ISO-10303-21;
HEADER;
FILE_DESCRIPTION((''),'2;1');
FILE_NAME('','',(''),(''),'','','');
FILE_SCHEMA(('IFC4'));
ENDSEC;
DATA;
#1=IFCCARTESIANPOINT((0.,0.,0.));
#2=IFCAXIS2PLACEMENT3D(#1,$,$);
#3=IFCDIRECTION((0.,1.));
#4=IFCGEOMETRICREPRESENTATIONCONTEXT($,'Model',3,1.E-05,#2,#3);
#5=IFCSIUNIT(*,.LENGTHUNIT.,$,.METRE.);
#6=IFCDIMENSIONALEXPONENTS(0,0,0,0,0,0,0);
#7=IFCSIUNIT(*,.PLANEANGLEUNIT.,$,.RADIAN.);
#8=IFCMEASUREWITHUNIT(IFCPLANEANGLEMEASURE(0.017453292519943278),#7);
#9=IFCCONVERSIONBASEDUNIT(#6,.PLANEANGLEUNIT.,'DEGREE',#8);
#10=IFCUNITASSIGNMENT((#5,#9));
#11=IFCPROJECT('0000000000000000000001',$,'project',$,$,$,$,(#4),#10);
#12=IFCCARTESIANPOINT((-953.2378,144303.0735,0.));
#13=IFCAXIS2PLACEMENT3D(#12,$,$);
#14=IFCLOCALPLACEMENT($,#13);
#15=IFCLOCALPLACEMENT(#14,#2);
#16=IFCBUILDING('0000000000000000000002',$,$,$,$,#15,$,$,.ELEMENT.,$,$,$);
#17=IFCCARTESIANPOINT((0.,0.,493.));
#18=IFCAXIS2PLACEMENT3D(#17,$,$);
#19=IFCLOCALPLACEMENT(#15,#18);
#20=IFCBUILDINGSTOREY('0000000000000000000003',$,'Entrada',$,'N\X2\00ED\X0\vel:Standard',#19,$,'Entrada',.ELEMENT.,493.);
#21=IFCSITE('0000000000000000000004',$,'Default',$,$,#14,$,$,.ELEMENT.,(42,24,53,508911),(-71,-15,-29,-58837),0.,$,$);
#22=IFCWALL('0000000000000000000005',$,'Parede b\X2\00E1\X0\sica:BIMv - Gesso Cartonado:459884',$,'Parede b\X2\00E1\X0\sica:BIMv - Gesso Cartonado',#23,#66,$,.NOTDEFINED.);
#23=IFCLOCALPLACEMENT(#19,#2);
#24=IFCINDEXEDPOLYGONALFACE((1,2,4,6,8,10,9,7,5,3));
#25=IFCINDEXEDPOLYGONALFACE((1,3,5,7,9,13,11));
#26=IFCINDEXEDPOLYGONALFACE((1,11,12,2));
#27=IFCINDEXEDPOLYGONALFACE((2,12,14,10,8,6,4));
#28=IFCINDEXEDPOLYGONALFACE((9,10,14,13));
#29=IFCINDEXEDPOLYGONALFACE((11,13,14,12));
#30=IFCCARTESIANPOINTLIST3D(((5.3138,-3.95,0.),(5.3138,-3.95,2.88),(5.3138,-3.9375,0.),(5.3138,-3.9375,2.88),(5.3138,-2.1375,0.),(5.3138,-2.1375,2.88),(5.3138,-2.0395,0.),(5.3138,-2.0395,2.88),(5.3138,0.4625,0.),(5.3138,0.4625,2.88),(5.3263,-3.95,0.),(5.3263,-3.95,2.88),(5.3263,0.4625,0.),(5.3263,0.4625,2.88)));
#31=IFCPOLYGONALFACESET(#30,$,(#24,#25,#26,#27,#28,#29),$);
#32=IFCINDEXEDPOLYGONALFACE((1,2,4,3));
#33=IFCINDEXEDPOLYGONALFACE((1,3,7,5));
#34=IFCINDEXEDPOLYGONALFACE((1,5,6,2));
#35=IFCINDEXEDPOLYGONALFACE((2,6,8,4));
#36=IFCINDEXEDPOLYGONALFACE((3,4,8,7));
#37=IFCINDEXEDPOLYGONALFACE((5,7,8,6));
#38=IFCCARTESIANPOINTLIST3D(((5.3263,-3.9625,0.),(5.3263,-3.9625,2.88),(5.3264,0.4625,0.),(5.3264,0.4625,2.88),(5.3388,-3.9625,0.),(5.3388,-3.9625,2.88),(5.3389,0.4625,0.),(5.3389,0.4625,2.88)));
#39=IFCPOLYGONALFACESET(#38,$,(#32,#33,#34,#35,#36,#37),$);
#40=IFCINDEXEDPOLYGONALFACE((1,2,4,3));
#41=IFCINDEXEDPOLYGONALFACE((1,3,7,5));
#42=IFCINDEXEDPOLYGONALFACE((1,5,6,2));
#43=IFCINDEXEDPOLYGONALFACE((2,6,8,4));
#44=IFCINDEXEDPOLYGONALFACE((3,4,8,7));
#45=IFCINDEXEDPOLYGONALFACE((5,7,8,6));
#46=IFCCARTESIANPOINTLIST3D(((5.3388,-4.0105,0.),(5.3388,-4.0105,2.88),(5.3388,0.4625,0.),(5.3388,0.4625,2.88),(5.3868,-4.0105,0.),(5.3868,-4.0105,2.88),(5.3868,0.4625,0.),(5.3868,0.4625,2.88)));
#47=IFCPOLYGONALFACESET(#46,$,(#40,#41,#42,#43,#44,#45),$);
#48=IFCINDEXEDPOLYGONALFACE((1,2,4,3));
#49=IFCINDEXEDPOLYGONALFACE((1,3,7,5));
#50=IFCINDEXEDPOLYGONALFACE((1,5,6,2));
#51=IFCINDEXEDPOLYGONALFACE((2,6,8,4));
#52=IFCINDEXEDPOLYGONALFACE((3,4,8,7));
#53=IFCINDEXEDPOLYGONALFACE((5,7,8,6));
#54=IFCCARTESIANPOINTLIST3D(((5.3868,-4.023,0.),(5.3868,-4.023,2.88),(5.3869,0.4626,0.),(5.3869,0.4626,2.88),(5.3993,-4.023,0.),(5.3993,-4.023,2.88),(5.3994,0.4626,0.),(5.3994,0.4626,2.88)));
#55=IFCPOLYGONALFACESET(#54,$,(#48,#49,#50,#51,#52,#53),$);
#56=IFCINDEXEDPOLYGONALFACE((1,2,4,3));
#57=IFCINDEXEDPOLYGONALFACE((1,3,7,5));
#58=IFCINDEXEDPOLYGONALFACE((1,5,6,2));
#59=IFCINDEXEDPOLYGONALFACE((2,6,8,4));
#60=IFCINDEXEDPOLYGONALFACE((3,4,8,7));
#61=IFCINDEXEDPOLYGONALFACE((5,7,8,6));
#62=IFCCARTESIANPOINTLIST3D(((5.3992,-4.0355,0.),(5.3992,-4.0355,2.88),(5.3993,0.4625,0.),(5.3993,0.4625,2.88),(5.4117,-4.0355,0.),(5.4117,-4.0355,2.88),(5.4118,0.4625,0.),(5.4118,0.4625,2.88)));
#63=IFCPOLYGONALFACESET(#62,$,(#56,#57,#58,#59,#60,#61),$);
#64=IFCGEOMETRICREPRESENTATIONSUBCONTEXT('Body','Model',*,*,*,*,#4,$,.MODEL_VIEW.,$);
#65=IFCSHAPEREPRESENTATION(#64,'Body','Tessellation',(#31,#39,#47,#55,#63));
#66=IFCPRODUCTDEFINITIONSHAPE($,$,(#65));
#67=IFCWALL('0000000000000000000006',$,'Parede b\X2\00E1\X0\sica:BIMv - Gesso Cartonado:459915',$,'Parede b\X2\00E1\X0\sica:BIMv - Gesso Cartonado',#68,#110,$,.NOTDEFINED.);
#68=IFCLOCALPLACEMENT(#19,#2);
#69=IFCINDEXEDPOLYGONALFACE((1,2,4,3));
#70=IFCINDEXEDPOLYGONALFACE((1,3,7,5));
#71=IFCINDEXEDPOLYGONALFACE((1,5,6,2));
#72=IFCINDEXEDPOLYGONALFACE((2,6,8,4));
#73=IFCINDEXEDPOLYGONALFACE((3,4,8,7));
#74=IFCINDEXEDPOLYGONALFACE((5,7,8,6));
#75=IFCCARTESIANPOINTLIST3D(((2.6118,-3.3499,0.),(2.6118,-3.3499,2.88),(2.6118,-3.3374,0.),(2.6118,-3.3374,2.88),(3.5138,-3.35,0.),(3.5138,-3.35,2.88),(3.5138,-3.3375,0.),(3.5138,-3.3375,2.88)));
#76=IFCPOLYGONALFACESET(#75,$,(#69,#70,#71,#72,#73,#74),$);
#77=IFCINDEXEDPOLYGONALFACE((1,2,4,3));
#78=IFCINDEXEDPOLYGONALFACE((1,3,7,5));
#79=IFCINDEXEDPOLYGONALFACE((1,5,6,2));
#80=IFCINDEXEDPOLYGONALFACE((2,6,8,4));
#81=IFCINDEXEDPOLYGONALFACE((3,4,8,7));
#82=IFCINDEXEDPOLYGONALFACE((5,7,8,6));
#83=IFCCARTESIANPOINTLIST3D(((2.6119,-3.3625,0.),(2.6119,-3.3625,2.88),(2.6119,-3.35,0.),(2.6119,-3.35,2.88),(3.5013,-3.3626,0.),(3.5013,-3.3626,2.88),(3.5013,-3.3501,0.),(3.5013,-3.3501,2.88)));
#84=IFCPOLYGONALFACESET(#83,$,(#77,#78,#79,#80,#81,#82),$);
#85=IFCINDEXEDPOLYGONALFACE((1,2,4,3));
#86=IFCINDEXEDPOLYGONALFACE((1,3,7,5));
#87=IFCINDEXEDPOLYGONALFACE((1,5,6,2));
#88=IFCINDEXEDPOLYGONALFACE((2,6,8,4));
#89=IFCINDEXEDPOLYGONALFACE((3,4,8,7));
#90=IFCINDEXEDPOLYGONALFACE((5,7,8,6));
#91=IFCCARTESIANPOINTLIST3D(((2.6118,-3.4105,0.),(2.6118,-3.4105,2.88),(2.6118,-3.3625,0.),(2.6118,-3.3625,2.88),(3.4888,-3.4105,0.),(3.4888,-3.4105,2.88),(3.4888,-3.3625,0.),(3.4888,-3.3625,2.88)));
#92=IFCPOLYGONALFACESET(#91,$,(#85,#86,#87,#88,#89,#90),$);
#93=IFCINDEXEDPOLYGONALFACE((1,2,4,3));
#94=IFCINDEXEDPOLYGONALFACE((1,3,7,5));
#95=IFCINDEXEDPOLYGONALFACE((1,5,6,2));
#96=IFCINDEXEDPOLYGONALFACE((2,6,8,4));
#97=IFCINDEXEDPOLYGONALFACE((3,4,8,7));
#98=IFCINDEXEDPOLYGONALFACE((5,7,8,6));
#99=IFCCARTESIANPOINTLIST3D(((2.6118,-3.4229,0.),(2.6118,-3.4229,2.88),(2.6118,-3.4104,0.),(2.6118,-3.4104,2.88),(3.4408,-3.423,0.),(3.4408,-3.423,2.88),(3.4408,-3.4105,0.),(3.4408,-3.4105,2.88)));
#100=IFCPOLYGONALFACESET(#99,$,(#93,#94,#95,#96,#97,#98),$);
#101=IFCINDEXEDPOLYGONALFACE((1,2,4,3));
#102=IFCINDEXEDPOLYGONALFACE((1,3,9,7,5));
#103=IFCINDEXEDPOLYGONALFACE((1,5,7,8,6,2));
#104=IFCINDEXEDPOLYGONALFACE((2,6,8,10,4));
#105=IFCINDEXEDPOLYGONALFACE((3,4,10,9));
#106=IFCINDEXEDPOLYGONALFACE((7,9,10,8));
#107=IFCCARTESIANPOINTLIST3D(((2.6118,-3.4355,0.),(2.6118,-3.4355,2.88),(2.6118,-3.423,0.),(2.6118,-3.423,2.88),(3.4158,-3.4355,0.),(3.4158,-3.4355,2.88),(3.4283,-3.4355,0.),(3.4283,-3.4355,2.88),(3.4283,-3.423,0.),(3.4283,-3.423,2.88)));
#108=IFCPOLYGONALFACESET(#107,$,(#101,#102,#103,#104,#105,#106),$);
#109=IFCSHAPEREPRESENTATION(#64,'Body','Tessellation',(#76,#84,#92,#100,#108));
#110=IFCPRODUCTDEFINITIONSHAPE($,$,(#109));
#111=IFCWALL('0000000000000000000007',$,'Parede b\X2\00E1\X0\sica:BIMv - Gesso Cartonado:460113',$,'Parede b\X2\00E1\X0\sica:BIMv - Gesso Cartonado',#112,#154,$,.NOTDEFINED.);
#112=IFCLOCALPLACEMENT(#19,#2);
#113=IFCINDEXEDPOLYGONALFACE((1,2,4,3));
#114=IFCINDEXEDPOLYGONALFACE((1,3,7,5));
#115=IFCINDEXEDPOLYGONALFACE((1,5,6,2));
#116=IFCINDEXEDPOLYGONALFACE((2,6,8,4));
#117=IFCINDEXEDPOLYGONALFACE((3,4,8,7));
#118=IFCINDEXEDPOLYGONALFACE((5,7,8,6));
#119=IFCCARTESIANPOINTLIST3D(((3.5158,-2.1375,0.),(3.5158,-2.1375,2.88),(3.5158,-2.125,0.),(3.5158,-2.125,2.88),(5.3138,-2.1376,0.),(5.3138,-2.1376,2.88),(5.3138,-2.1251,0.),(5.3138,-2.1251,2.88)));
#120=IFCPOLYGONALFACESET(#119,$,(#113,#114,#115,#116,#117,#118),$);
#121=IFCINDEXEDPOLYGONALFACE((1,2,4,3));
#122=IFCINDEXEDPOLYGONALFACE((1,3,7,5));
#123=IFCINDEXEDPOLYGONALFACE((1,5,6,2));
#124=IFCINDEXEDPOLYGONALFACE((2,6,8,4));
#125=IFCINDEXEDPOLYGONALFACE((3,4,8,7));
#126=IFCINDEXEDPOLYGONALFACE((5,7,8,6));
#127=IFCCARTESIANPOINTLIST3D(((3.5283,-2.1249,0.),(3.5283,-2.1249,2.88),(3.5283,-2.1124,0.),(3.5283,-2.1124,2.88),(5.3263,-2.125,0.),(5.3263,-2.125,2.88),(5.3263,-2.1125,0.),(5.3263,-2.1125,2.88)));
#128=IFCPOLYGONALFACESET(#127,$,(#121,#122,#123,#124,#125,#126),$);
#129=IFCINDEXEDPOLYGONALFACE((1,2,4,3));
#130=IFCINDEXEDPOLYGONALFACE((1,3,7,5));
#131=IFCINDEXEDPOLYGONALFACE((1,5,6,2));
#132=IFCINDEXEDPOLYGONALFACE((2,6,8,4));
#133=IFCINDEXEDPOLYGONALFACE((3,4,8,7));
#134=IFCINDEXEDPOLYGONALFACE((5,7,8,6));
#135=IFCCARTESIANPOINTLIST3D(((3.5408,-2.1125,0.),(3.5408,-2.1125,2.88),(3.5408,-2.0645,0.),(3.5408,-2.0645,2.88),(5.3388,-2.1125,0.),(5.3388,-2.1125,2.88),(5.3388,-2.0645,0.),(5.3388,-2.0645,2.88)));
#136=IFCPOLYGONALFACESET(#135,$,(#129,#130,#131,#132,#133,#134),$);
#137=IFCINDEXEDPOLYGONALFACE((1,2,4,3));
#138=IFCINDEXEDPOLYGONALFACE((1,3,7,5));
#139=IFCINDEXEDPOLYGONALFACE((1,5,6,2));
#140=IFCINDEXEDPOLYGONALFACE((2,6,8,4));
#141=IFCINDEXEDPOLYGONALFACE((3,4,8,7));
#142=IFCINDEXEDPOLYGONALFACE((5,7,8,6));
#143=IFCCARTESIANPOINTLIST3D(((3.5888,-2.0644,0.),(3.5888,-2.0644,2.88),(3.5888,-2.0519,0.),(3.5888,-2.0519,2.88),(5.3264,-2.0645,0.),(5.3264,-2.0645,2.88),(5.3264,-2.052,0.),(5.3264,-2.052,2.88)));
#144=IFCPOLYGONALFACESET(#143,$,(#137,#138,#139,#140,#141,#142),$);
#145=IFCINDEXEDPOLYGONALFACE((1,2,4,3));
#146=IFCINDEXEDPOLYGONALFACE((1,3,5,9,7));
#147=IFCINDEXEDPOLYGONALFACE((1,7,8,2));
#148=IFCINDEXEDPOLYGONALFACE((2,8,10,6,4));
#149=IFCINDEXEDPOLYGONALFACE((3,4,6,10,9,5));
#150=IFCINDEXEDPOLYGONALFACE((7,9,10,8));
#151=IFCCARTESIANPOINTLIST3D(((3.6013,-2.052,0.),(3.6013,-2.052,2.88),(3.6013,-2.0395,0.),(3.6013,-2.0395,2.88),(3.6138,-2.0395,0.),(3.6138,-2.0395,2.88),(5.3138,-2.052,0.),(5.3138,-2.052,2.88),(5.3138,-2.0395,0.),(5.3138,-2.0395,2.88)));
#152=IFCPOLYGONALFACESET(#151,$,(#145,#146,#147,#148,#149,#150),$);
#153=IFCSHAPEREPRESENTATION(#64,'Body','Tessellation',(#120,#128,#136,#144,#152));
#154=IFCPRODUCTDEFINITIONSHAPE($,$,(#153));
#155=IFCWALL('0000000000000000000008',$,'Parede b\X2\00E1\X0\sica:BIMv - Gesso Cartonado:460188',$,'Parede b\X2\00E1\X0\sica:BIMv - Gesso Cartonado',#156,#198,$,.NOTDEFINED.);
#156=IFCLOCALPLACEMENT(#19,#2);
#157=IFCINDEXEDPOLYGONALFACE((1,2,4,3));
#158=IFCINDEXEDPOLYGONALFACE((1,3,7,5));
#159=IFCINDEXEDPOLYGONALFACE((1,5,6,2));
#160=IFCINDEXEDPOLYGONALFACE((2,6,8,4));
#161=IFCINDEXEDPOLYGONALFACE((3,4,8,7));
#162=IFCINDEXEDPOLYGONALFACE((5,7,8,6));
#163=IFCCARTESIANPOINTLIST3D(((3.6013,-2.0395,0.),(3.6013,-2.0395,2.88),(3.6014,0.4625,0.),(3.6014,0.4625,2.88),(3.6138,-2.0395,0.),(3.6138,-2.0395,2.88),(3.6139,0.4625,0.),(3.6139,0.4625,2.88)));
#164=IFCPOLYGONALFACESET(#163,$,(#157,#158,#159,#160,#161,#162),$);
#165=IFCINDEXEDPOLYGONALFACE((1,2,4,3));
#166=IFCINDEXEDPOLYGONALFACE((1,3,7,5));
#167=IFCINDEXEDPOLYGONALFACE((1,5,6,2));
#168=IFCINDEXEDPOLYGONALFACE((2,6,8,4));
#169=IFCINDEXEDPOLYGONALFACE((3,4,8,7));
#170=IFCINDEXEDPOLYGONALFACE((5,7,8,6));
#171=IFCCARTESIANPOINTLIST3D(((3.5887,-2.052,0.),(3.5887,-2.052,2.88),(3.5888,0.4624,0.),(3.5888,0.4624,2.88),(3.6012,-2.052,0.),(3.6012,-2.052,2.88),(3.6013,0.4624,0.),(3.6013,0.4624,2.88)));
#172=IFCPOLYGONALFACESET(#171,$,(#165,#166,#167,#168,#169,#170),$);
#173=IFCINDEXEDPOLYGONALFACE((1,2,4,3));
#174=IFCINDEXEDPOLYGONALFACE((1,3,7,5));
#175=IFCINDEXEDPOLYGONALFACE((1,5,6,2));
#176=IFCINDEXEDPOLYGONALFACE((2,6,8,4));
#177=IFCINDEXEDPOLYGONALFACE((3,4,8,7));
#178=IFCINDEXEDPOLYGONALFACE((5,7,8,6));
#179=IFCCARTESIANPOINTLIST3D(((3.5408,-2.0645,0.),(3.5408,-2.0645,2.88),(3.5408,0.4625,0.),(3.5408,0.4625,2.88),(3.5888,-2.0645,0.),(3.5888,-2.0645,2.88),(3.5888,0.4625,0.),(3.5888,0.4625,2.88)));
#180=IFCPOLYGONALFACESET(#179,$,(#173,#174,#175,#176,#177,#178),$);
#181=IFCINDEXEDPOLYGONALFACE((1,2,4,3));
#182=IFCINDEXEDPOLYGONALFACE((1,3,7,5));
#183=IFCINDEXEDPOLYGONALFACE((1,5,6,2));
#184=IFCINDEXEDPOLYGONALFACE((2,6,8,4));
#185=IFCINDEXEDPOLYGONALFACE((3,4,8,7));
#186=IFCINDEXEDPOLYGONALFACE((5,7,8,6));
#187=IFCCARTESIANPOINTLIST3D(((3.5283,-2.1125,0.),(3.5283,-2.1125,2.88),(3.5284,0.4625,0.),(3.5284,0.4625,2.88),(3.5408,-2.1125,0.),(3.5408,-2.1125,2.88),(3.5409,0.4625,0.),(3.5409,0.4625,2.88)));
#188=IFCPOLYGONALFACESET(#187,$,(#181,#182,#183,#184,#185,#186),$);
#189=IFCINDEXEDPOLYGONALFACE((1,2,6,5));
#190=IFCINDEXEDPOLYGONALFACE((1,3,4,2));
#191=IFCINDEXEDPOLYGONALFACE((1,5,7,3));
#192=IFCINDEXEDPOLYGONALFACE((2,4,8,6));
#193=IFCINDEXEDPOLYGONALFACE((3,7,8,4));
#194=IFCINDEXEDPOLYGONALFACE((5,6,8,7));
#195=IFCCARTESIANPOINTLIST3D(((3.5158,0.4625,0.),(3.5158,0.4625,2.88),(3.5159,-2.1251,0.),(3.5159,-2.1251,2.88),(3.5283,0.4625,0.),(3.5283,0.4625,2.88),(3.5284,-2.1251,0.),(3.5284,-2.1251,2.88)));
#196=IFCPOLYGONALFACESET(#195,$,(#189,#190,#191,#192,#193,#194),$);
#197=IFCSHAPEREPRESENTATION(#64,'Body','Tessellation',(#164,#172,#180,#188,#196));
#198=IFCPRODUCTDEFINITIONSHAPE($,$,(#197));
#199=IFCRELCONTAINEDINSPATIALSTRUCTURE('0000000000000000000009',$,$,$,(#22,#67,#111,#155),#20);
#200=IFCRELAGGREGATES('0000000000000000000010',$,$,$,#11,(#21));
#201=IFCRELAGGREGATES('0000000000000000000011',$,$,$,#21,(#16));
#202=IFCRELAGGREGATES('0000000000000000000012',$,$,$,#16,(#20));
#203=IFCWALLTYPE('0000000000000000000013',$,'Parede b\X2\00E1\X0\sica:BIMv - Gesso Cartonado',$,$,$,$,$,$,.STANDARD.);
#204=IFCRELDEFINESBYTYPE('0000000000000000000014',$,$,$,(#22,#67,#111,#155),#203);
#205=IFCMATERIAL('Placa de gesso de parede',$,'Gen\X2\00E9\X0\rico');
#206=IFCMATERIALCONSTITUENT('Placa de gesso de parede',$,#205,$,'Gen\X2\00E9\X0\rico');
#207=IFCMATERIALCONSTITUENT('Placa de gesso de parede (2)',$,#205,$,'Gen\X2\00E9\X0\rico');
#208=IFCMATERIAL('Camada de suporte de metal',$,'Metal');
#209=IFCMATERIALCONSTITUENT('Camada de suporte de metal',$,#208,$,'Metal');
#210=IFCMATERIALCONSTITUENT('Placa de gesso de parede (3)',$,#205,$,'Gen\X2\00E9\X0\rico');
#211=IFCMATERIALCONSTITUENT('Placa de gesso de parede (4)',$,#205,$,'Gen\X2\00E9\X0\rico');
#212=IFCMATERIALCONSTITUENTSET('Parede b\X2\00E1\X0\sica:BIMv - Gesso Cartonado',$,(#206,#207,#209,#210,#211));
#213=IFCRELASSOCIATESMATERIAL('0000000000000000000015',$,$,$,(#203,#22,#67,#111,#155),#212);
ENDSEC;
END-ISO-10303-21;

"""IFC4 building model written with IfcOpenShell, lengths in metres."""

from ifc_helpers import new_model, entity, si_unit, converted_unit, direction, frame, origin, place, context, subcontext, project, spatial, indexed_curve, outline, extrude, material, constituent, constituent_set, type_object, element, save


model = new_model("IFC4")

# Units and contexts
model_context = context("Model", 3, precision=1e-05, world=origin(), true_north=direction((0.0, 1.0)))
body_context = subcontext(model_context, "Body", "Model", "MODEL_VIEW")
ifc_project = project(units=[si_unit("LENGTHUNIT", "METRE"), converted_unit("PLANEANGLEUNIT", "DEGREE", entity("IfcPlaneAngleMeasure", 0.017453292519943278), si_unit("PLANEANGLEUNIT", "RADIAN"), dimensions=[0, 0, 0, 0, 0, 0, 0])], contexts=[model_context])

# Site, building, storey
site_placement = place(None, frame((-953.2378, 144303.0735, 0.0)))
site = spatial("IfcSite", under=ifc_project, at=site_placement, Name="Default", CompositionType="ELEMENT", RefLatitude=(42, 24, 53, 508911), RefLongitude=(-71, -15, -29, -58837), RefElevation=0.0)
building_placement = place(site_placement, origin())
building = spatial("IfcBuilding", under=site, at=building_placement, CompositionType="ELEMENT")
storey_placement = place(building_placement, frame((0.0, 0.0, 493.0)))
storey = spatial("IfcBuildingStorey", under=building, at=storey_placement, Name="Entrada", ObjectType="Nível:Standard", LongName="Entrada", CompositionType="ELEMENT", Elevation=493.0)

# Walls
ifc_material_1 = material(Name="Placa de gesso de parede", Category="Genérico")
ifc_constituent_1 = constituent(ifc_material_1, Name="Placa de gesso de parede", Category="Genérico")
ifc_constituent_2 = constituent(ifc_material_1, Name="Placa de gesso de parede (2)", Category="Genérico")
ifc_material_2 = material(Name="Camada de suporte de metal", Category="Metal")
ifc_constituent_3 = constituent(ifc_material_2, Name="Camada de suporte de metal", Category="Metal")
ifc_constituent_4 = constituent(ifc_material_1, Name="Placa de gesso de parede (3)", Category="Genérico")
ifc_constituent_5 = constituent(ifc_material_1, Name="Placa de gesso de parede (4)", Category="Genérico")
ifc_constituent_set_1 = constituent_set(constituents=[ifc_constituent_1, ifc_constituent_2, ifc_constituent_3, ifc_constituent_4, ifc_constituent_5], Name="Parede básica:BIMv - Gesso Cartonado")
wall_type = type_object("IfcWallType", Name="Parede básica:BIMv - Gesso Cartonado", PredefinedType="STANDARD", material=ifc_constituent_set_1)
wall_1_placement = place(storey_placement, frame((5.3628, 0.4625, 0.0), z_axis=(0.0, 0.0, 1.0), x_axis=(0.0, -1.0, 0.0)))
element("IfcWall", 1, at=wall_1_placement, inside=storey, type_object=wall_type, material=ifc_constituent_set_1, Name="Parede básica:BIMv - Gesso Cartonado:459884", ObjectType="Parede básica:BIMv - Gesso Cartonado", PredefinedType="NOTDEFINED", context=body_context, shape_type="SweptSolid", body=[
    extrude(outline(indexed_curve([(-0.1161, -0.0036), (-0.0181, -0.0036), (1.7819, -0.0036), (1.7944, -0.0036), (1.7944, 0.0089), (-2.6181, 0.0089), (-2.6181, -0.0036), (-0.1161, -0.0036)], self_intersect=False)), frame((2.6181, -0.0454, 0.0)), (0.0, 0.0, 1.0), 2.88),
    extrude(outline(indexed_curve([(-0.0063, -2.2125), (0.0062, -2.2125), (0.0063, 2.2125), (-0.0062, 2.2125), (-0.0063, -2.2125)], self_intersect=False)), frame((2.2125, -0.0302, 0.0), z_axis=(0.0, 0.0, 1.0), x_axis=(0.0, 1.0, 0.0)), (0.0, 0.0, 1.0), 2.88),
    extrude(outline(indexed_curve([(-0.024, -2.2365), (0.024, -2.2365), (0.024, 2.2365), (-0.024, 2.2365), (-0.024, -2.2365)], self_intersect=False)), frame((2.2365, 0.0, 0.0), z_axis=(0.0, 0.0, 1.0), x_axis=(0.0, 1.0, 0.0)), (0.0, 0.0, 1.0), 2.88),
    extrude(outline(indexed_curve([(-0.0063, -2.2428), (0.0062, -2.2428), (0.0063, 2.2428), (-0.0062, 2.2428), (-0.0063, -2.2428)], self_intersect=False)), frame((2.2427, 0.0303, 0.0), z_axis=(0.0, 0.0, 1.0), x_axis=(0.0, 1.0, 0.0)), (0.0, 0.0, 1.0), 2.88),
    extrude(outline(indexed_curve([(-0.0063, -2.249), (0.0062, -2.249), (0.0063, 2.249), (-0.0062, 2.249), (-0.0063, -2.249)], self_intersect=False)), frame((2.249, 0.0427, 0.0), z_axis=(0.0, 0.0, 1.0), x_axis=(0.0, 1.0, 0.0)), (0.0, 0.0, 1.0), 2.88),
])
wall_2_placement = place(storey_placement, frame((3.5138, -3.3865, 0.0), z_axis=(0.0, 0.0, 1.0), x_axis=(-1.0, 0.0, 0.0)))
element("IfcWall", 2, at=wall_2_placement, inside=storey, type_object=wall_type, material=ifc_constituent_set_1, Name="Parede básica:BIMv - Gesso Cartonado:459915", ObjectType="Parede básica:BIMv - Gesso Cartonado", PredefinedType="NOTDEFINED", context=body_context, shape_type="SweptSolid", body=[
    extrude(outline(indexed_curve([(-0.0063, -0.451), (0.0062, -0.451), (0.0063, 0.451), (-0.0062, 0.451), (-0.0063, -0.451)], self_intersect=False)), frame((0.451, -0.0428, 0.0), z_axis=(0.0, 0.0, 1.0), x_axis=(0.0, 1.0, 0.0)), (0.0, 0.0, 1.0), 2.88),
    extrude(outline(indexed_curve([(-0.4447, -0.0062), (0.4447, -0.0063), (0.4447, 0.0062), (-0.4447, 0.0063), (-0.4447, -0.0062)], self_intersect=False)), frame((0.4572, -0.0302, 0.0)), (0.0, 0.0, 1.0), 2.88),
    extrude(outline(indexed_curve([(-0.4385, -0.024), (0.4385, -0.024), (0.4385, 0.024), (-0.4385, 0.024), (-0.4385, -0.024)], self_intersect=False)), frame((0.4635, 0.0, 0.0)), (0.0, 0.0, 1.0), 2.88),
    extrude(outline(indexed_curve([(-0.4145, -0.0062), (0.4145, -0.0063), (0.4145, 0.0062), (-0.4145, 0.0063), (-0.4145, -0.0062)], self_intersect=False)), frame((0.4875, 0.0302, 0.0)), (0.0, 0.0, 1.0), 2.88),
    extrude(outline(indexed_curve([(0.3166, -0.005), (0.3291, -0.005), (0.3291, 0.0075), (-0.4874, 0.0075), (-0.4874, -0.005), (0.3166, -0.005)], self_intersect=False)), frame((0.4146, 0.044, 0.0), z_axis=(0.0, 0.0, 1.0), x_axis=(-1.0, 0.0, 0.0)), (0.0, 0.0, 1.0), 2.88),
])
wall_3_placement = place(storey_placement, frame((3.5158, -2.0885, 0.0)))
element("IfcWall", 3, at=wall_3_placement, inside=storey, type_object=wall_type, material=ifc_constituent_set_1, Name="Parede básica:BIMv - Gesso Cartonado:460113", ObjectType="Parede básica:BIMv - Gesso Cartonado", PredefinedType="NOTDEFINED", context=body_context, shape_type="SweptSolid", body=[
    extrude(outline(indexed_curve([(-0.0063, -0.899), (0.0062, -0.899), (0.0063, 0.899), (-0.0062, 0.899), (-0.0063, -0.899)], self_intersect=False)), frame((0.899, -0.0428, 0.0), z_axis=(0.0, 0.0, 1.0), x_axis=(0.0, 1.0, 0.0)), (0.0, 0.0, 1.0), 2.88),
    extrude(outline(indexed_curve([(-0.899, -0.0062), (0.899, -0.0063), (0.899, 0.0062), (-0.899, 0.0063), (-0.899, -0.0062)], self_intersect=False)), frame((0.9115, -0.0302, 0.0)), (0.0, 0.0, 1.0), 2.88),
    extrude(outline(indexed_curve([(-0.899, -0.024), (0.899, -0.024), (0.899, 0.024), (-0.899, 0.024), (-0.899, -0.024)], self_intersect=False)), frame((0.924, 0.0, 0.0)), (0.0, 0.0, 1.0), 2.88),
    extrude(outline(indexed_curve([(-0.8688, -0.0062), (0.8688, -0.0063), (0.8688, 0.0062), (-0.8688, 0.0063), (-0.8688, -0.0062)], self_intersect=False)), frame((0.9418, 0.0303, 0.0)), (0.0, 0.0, 1.0), 2.88),
    extrude(outline(indexed_curve([(0.675, -0.005), (0.6875, -0.005), (0.6875, 0.0075), (-1.025, 0.0075), (-1.025, -0.005), (0.675, -0.005)], self_intersect=False)), frame((0.773, 0.044, 0.0), z_axis=(0.0, 0.0, 1.0), x_axis=(-1.0, 0.0, 0.0)), (0.0, 0.0, 1.0), 2.88),
])
wall_4_placement = place(storey_placement, frame((3.5648, -2.0395, 0.0), z_axis=(0.0, 0.0, 1.0), x_axis=(0.0, 1.0, 0.0)))
element("IfcWall", 4, at=wall_4_placement, inside=storey, type_object=wall_type, material=ifc_constituent_set_1, Name="Parede básica:BIMv - Gesso Cartonado:460188", ObjectType="Parede básica:BIMv - Gesso Cartonado", PredefinedType="NOTDEFINED", context=body_context, shape_type="SweptSolid", body=[
    extrude(outline(indexed_curve([(-0.0063, -1.251), (0.0062, -1.251), (0.0063, 1.251), (-0.0062, 1.251), (-0.0063, -1.251)], self_intersect=False)), frame((1.251, -0.0428, 0.0), z_axis=(0.0, 0.0, 1.0), x_axis=(0.0, 1.0, 0.0)), (0.0, 0.0, 1.0), 2.88),
    extrude(outline(indexed_curve([(-0.0063, -1.2572), (0.0062, -1.2572), (0.0063, 1.2572), (-0.0062, 1.2572), (-0.0063, -1.2572)], self_intersect=False)), frame((1.2447, -0.0302, 0.0), z_axis=(0.0, 0.0, 1.0), x_axis=(0.0, 1.0, 0.0)), (0.0, 0.0, 1.0), 2.88),
    extrude(outline(indexed_curve([(-0.024, -1.2635), (0.024, -1.2635), (0.024, 1.2635), (-0.024, 1.2635), (-0.024, -1.2635)], self_intersect=False)), frame((1.2385, 0.0, 0.0), z_axis=(0.0, 0.0, 1.0), x_axis=(0.0, 1.0, 0.0)), (0.0, 0.0, 1.0), 2.88),
    extrude(outline(indexed_curve([(-0.0063, -1.2875), (0.0062, -1.2875), (0.0063, 1.2875), (-0.0062, 1.2875), (-0.0063, -1.2875)], self_intersect=False)), frame((1.2145, 0.0302, 0.0), z_axis=(0.0, 0.0, 1.0), x_axis=(0.0, 1.0, 0.0)), (0.0, 0.0, 1.0), 2.88),
    extrude(outline(indexed_curve([(-0.0062, -1.2938), (0.0063, -1.2938), (0.0062, 1.2938), (-0.0063, 1.2938), (-0.0062, -1.2938)], self_intersect=False)), frame((1.2082, 0.0427, 0.0), z_axis=(0.0, 0.0, 1.0), x_axis=(0.0, 1.0, 0.0)), (0.0, 0.0, 1.0), 2.88),
])

save(model, "model.ifc")
